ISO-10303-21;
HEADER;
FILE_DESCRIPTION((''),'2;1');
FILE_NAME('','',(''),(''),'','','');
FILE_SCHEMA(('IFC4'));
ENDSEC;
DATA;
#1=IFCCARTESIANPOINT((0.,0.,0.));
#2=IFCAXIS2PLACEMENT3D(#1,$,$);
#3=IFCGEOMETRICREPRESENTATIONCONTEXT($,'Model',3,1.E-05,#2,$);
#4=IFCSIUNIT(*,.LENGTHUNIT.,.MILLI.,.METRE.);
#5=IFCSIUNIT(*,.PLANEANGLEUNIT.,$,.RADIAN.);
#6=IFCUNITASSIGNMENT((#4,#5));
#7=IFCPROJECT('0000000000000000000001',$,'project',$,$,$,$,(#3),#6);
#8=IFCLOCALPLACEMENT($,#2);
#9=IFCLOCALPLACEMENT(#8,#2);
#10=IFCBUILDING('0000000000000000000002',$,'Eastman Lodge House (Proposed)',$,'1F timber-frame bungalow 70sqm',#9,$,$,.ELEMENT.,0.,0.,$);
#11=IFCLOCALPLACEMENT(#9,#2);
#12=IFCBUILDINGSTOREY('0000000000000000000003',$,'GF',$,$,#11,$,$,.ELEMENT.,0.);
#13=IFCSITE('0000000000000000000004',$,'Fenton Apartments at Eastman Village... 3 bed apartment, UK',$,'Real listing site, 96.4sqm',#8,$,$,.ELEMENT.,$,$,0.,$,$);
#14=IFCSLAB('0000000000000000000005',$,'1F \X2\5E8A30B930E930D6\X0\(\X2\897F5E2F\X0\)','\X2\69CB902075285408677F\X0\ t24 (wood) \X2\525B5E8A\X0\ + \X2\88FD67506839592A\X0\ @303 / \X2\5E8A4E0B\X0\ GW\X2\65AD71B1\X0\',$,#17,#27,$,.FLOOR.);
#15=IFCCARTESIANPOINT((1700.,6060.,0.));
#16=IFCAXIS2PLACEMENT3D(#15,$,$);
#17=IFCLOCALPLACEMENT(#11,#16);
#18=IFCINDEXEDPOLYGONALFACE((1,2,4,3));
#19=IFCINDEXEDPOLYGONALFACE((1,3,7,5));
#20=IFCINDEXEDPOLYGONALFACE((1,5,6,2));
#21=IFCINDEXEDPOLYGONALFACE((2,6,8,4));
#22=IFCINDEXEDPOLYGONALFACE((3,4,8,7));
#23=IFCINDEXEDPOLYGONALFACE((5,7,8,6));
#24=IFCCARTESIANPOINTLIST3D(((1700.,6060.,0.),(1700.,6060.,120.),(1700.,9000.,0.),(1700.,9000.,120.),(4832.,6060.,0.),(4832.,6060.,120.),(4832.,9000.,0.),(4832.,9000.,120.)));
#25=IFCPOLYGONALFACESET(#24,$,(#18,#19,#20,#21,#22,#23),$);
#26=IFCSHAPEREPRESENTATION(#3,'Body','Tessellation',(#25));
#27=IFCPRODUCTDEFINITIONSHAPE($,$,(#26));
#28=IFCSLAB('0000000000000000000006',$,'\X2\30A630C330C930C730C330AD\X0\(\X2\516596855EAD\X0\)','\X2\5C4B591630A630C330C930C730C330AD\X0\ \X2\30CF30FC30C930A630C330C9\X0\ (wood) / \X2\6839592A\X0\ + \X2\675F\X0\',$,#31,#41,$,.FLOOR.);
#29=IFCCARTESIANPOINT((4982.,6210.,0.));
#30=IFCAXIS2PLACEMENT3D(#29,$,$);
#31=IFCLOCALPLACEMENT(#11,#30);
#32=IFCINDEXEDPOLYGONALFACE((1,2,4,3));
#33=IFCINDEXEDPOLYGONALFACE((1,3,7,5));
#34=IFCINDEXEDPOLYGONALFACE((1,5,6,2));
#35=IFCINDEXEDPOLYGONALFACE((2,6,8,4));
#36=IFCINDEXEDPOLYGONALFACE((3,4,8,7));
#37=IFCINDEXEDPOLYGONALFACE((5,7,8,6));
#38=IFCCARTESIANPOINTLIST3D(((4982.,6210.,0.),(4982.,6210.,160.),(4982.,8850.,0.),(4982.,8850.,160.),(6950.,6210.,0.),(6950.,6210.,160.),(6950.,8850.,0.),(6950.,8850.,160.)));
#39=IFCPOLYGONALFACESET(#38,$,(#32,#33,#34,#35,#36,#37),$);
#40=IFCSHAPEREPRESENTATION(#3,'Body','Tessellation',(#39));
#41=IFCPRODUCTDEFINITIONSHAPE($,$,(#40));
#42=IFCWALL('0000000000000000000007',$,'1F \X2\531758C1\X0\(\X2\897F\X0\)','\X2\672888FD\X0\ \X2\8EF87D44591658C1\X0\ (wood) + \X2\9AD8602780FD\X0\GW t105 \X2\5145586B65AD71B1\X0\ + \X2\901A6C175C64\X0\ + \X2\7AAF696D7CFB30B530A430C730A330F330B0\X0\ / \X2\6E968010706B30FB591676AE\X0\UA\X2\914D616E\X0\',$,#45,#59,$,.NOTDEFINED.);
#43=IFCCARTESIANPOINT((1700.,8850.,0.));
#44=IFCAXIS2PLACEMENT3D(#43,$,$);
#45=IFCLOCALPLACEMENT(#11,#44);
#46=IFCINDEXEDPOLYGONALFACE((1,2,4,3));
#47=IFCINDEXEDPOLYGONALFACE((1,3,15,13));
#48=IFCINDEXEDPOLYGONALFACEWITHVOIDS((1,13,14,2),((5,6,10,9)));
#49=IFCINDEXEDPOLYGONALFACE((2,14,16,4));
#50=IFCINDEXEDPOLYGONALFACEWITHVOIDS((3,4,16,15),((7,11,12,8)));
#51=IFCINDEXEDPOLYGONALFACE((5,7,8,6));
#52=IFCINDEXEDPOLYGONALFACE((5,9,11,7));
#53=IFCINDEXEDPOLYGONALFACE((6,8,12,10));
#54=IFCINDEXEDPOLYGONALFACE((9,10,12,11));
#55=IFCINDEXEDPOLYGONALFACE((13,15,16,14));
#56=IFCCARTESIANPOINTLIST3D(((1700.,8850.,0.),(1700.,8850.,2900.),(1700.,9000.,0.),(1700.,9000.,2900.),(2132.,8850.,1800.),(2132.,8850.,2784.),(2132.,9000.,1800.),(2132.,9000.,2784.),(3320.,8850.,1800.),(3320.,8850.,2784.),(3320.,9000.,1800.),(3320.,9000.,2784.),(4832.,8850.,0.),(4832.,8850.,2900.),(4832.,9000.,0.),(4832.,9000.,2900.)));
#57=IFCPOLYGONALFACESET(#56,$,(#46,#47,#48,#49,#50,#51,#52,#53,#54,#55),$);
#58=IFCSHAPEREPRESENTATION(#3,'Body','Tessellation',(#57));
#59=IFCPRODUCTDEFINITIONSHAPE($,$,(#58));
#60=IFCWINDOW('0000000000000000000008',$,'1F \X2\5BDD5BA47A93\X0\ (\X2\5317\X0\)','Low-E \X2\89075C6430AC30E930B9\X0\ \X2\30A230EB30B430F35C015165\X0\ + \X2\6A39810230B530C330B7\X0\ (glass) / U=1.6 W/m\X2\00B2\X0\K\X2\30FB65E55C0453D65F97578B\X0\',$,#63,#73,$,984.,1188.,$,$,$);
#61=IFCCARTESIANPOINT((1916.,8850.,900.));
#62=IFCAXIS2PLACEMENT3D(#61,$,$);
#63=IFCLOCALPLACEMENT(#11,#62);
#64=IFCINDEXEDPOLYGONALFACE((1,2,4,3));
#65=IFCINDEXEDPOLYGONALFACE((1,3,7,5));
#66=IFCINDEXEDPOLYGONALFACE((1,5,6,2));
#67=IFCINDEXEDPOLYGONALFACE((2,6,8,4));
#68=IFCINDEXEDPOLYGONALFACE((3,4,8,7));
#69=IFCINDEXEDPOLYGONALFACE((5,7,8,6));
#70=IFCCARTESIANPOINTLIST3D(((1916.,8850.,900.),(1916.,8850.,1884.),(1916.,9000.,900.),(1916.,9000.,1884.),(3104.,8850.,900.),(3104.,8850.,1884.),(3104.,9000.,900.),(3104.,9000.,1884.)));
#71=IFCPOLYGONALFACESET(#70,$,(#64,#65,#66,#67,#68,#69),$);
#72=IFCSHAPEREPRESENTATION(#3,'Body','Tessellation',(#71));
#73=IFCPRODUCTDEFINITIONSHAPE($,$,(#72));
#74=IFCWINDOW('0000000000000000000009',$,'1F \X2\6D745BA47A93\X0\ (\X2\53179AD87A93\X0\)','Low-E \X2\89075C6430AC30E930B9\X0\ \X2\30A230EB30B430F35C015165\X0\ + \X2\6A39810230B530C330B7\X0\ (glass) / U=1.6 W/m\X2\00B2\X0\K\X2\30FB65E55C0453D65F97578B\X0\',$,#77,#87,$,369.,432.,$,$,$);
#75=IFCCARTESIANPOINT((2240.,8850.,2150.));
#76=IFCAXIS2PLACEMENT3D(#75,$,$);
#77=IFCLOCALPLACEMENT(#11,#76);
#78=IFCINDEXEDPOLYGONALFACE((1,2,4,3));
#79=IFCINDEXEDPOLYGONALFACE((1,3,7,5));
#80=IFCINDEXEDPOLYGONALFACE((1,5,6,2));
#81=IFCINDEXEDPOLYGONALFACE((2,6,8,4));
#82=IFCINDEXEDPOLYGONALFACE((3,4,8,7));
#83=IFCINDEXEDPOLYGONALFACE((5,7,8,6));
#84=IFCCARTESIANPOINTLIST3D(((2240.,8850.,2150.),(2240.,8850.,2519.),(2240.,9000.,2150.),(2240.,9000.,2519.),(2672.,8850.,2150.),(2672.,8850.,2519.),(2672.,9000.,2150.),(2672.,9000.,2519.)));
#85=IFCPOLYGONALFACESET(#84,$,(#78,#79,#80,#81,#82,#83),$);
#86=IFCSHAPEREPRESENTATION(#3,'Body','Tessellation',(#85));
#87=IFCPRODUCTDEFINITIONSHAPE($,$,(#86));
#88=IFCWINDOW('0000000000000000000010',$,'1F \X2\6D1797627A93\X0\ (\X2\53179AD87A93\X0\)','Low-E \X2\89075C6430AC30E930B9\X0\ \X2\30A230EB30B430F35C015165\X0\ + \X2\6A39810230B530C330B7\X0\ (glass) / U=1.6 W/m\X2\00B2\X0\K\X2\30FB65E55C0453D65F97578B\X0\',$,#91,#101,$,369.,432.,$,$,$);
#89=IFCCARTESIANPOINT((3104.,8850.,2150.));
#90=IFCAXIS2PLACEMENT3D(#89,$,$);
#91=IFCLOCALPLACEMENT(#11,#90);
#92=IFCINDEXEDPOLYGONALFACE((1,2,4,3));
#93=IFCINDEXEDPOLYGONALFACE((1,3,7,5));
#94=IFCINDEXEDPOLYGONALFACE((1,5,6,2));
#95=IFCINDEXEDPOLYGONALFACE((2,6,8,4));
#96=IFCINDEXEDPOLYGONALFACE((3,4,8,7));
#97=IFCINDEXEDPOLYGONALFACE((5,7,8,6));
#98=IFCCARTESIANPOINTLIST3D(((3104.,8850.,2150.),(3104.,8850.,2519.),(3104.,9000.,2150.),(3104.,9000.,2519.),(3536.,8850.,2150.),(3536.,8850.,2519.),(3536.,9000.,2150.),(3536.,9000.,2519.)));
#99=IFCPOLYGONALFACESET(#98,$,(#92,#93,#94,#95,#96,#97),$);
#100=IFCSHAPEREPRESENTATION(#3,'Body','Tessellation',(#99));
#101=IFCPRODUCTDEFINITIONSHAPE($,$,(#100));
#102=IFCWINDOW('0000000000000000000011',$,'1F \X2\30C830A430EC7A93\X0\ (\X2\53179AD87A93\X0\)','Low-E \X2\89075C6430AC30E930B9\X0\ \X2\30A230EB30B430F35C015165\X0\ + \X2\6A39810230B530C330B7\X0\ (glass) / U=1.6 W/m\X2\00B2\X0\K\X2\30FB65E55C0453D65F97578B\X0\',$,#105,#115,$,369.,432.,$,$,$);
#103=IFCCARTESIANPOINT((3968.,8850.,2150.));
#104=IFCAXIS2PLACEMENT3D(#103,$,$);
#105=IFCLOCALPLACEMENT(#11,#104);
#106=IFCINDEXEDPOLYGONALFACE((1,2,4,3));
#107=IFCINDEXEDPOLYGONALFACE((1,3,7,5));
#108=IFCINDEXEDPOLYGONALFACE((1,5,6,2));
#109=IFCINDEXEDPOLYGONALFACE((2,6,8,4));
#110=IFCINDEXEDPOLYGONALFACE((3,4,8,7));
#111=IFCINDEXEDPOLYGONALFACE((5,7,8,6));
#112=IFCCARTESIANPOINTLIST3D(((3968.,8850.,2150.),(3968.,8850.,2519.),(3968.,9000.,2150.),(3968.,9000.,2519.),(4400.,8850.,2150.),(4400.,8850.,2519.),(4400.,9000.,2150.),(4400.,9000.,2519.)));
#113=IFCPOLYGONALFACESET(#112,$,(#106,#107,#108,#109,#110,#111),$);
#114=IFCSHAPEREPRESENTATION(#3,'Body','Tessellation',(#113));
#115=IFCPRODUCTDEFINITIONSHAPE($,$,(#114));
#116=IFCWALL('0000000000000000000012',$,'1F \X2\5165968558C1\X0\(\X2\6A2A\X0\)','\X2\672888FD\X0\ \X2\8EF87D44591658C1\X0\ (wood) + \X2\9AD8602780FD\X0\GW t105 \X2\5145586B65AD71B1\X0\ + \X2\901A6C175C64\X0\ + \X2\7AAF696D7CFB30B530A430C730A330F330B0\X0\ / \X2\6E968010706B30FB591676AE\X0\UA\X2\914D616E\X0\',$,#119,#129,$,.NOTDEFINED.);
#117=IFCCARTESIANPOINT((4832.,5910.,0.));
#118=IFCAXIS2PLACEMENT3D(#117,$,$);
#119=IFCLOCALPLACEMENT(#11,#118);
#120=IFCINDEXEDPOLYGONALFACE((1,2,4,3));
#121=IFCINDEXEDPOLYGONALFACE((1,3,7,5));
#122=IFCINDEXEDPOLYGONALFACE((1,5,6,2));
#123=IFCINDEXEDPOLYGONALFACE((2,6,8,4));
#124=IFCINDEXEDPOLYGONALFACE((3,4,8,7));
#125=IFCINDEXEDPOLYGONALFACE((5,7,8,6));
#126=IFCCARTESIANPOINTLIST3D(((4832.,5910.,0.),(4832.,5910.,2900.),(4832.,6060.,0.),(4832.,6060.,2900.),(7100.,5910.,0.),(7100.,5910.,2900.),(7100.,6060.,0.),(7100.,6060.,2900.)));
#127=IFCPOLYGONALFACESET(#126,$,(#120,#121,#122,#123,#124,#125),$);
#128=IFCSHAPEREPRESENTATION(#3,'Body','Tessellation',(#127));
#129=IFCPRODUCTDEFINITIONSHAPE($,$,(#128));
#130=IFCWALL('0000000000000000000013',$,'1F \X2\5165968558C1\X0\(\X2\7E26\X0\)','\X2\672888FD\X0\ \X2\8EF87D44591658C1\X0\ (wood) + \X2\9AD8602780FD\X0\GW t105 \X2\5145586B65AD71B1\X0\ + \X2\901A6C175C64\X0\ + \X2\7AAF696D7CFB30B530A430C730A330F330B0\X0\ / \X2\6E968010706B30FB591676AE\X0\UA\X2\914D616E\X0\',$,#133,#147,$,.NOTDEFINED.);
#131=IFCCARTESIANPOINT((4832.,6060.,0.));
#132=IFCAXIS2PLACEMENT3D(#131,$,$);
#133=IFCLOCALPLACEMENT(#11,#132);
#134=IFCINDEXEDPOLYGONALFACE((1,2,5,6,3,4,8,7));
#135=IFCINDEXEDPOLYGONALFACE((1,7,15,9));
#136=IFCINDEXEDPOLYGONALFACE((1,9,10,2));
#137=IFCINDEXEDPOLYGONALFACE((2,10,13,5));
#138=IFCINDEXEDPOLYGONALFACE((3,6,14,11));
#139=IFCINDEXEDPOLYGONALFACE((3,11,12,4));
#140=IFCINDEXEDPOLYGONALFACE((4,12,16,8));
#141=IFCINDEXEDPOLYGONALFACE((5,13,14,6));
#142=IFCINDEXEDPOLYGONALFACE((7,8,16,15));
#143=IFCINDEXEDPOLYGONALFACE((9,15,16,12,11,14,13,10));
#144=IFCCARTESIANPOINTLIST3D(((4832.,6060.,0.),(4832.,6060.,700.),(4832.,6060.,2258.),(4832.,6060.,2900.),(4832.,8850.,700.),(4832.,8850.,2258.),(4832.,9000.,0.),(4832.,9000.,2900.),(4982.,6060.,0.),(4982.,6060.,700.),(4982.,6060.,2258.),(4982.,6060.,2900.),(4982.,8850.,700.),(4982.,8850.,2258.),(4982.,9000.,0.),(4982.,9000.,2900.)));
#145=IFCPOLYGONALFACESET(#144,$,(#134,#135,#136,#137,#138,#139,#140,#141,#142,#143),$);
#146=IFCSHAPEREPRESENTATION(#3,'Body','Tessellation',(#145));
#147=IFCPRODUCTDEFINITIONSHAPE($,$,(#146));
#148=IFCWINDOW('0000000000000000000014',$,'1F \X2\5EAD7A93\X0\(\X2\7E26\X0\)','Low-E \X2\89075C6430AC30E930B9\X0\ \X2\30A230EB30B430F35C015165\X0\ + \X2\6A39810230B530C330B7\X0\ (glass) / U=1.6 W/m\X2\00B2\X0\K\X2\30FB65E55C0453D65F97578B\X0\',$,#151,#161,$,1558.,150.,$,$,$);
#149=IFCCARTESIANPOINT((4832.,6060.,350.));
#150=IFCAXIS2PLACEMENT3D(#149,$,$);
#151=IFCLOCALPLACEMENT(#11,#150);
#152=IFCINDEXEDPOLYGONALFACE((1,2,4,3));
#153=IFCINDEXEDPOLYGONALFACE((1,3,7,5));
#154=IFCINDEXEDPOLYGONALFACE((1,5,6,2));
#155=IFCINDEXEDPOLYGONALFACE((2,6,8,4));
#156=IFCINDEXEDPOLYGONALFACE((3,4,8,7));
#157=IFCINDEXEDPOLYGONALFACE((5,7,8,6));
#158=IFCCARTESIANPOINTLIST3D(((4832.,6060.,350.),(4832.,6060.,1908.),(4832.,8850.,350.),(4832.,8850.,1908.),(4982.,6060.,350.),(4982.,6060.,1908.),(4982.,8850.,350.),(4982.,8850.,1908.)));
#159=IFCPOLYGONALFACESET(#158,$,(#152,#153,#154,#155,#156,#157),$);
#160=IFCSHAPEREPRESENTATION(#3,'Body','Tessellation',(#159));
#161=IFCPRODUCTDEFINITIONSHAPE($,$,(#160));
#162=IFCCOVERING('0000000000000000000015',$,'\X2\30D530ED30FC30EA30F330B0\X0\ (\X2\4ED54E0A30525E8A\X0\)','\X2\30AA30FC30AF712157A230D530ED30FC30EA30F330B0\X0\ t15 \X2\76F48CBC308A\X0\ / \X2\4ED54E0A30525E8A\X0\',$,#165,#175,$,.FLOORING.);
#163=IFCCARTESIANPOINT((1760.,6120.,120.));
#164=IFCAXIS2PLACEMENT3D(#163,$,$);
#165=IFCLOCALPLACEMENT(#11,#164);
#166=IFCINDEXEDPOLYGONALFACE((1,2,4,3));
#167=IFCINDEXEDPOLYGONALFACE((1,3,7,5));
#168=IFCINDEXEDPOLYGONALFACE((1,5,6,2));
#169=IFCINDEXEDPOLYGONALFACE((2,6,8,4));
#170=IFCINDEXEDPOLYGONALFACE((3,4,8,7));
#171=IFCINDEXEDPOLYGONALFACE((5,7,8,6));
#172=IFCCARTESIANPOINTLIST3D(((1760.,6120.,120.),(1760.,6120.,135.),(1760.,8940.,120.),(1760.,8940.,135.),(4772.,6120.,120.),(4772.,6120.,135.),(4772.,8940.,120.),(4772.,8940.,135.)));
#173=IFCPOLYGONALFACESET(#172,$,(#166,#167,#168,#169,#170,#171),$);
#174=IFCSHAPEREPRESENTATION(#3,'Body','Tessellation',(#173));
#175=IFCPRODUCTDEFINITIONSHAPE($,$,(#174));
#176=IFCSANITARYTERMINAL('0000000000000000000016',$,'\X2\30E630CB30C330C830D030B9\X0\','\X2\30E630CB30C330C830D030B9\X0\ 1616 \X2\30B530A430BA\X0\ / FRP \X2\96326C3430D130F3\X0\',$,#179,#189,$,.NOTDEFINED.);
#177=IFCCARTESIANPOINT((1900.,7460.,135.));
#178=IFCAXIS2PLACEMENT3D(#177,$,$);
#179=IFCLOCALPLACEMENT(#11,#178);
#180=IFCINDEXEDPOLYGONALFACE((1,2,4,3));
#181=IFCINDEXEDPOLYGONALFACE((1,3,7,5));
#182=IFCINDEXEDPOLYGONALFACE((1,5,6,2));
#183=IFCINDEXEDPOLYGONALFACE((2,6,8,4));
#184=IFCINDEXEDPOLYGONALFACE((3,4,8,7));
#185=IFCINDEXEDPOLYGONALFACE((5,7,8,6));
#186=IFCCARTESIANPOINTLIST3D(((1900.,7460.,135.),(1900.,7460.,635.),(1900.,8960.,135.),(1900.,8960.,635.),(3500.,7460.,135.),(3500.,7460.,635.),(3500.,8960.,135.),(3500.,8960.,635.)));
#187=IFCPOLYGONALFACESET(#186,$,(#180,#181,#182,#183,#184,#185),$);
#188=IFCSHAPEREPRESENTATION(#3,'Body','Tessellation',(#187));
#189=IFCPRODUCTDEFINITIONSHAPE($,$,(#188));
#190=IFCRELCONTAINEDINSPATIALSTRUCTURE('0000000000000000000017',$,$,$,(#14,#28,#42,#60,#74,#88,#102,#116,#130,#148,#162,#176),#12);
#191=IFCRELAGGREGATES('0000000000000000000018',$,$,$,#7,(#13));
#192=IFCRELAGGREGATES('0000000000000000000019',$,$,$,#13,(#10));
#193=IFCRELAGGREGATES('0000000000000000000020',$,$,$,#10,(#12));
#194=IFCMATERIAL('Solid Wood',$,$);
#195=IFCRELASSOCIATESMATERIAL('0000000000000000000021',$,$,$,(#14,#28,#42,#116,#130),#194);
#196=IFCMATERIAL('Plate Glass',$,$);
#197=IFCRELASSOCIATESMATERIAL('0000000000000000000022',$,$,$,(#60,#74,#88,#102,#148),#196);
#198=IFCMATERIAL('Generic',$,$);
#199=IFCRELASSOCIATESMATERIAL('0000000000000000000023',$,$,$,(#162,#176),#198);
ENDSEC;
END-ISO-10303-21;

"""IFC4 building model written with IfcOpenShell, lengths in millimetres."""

from ifc_helpers import new_model, si_unit, frame, frame_2d, origin, place, context, project, spatial, rectangle, extrude, material, element, fill, save


model = new_model("IFC4")

# Units and contexts
model_context = context("Model", 3, precision=1e-05, world=origin())
ifc_project = project(units=[si_unit("LENGTHUNIT", "METRE", prefix="MILLI"), si_unit("PLANEANGLEUNIT", "RADIAN")], contexts=[model_context])

# Site, building, storey
site_placement = place(None, origin())
site = spatial("IfcSite", under=ifc_project, at=site_placement, Name="Fenton Apartments at Eastman Village... 3 bed apartment, UK", ObjectType="Real listing site, 96.4sqm", CompositionType="ELEMENT", RefElevation=0.0)
building_placement = place(site_placement, origin())
building = spatial("IfcBuilding", under=site, at=building_placement, Name="Eastman Lodge House (Proposed)", ObjectType="1F timber-frame bungalow 70sqm", CompositionType="ELEMENT", ElevationOfRefHeight=0.0, ElevationOfTerrain=0.0)
storey_placement = place(building_placement, origin())
storey = spatial("IfcBuildingStorey", under=building, at=storey_placement, Name="GF", CompositionType="ELEMENT", Elevation=0.0)

# Slabs
ifc_material_1 = material(Name="Solid Wood")
slab_1_placement = place(storey_placement, frame((1700.0, 6060.0, 0.0)))
element("IfcSlab", 1, at=slab_1_placement, inside=storey, material=ifc_material_1, Name="1F 床スラブ(西帯)", Description="構造用合板 t24 (wood) 剛床 + 製材根太 @303 / 床下 GW断熱", PredefinedType="FLOOR", context=model_context, shape_type="SweptSolid", body=[
    extrude(rectangle(XDim=3132.0, YDim=2940.0, at=frame_2d((1566.0, 1470.0))), frame((1700.0, 6060.0, 0.0)), (0.0, 0.0, 1.0), 120.0),
])
slab_2_placement = place(storey_placement, frame((4982.0, 6210.0, 0.0)))
element("IfcSlab", 2, at=slab_2_placement, inside=storey, material=ifc_material_1, Name="ウッドデッキ(入隅庭)", Description="屋外ウッドデッキ ハードウッド (wood) / 根太 + 束", PredefinedType="FLOOR", context=model_context, shape_type="SweptSolid", body=[
    extrude(rectangle(XDim=1968.0, YDim=2640.0, at=frame_2d((984.0, 1320.0))), frame((4982.0, 6210.0, 0.0)), (0.0, 0.0, 1.0), 160.0),
])

# Wall, openings, windows
wall_1_placement = place(storey_placement, frame((1700.0, 8850.0, 0.0)))
wall_1 = element("IfcWall", 3, at=wall_1_placement, inside=storey, material=ifc_material_1, Name="1F 北壁(西)", Description="木製 軸組外壁 (wood) + 高性能GW t105 充填断熱 + 通気層 + 窯業系サイディング / 準耐火・外皮UA配慮", PredefinedType="NOTDEFINED", context=model_context, shape_type="SweptSolid", body=[
    extrude(rectangle(XDim=3132.0, YDim=150.0, at=frame_2d((1566.0, 75.0))), frame((1700.0, 8850.0, 0.0)), (0.0, 0.0, 1.0), 2900.0),
])
opening_1_placement = place(storey_placement, frame((1916.0, 8850.0, 900.0)))
opening_1 = element("IfcOpeningElement", 4, at=opening_1_placement, cuts=wall_1, PredefinedType="NOTDEFINED", context=model_context, shape_type="SweptSolid", body=[
    extrude(rectangle(XDim=1188.0, YDim=150.0, at=frame_2d((594.0, 75.0))), frame((1916.0, 8850.0, 900.0)), (0.0, 0.0, 1.0), 984.0),
])
opening_2_placement = place(storey_placement, frame((2240.0, 8850.0, 2150.0)))
opening_2 = element("IfcOpeningElement", 5, at=opening_2_placement, cuts=wall_1, PredefinedType="NOTDEFINED", context=model_context, shape_type="SweptSolid", body=[
    extrude(rectangle(XDim=432.0, YDim=150.0, at=frame_2d((216.0, 75.0))), frame((2240.0, 8850.0, 2150.0)), (0.0, 0.0, 1.0), 369.0),
])
opening_3_placement = place(storey_placement, frame((3104.0, 8850.0, 2150.0)))
opening_3 = element("IfcOpeningElement", 6, at=opening_3_placement, cuts=wall_1, PredefinedType="NOTDEFINED", context=model_context, shape_type="SweptSolid", body=[
    extrude(rectangle(XDim=432.0, YDim=150.0, at=frame_2d((216.0, 75.0))), frame((3104.0, 8850.0, 2150.0)), (0.0, 0.0, 1.0), 369.0),
])
opening_4_placement = place(storey_placement, frame((3968.0, 8850.0, 2150.0)))
opening_4 = element("IfcOpeningElement", 7, at=opening_4_placement, cuts=wall_1, PredefinedType="NOTDEFINED", context=model_context, shape_type="SweptSolid", body=[
    extrude(rectangle(XDim=432.0, YDim=150.0, at=frame_2d((216.0, 75.0))), frame((3968.0, 8850.0, 2150.0)), (0.0, 0.0, 1.0), 369.0),
])
ifc_material_2 = material(Name="Plate Glass")
window_1_placement = place(storey_placement, frame((1916.0, 8850.0, 900.0)))
window_1 = element("IfcWindow", 8, at=window_1_placement, inside=storey, material=ifc_material_2, Name="1F 寝室窓 (北)", Description="Low-E 複層ガラス アルゴン封入 + 樹脂サッシ (glass) / U=1.6 W/m²K・日射取得型", OverallHeight=984.0, OverallWidth=1188.0, context=model_context, shape_type="SweptSolid", body=[
    extrude(rectangle(XDim=1188.0, YDim=150.0, at=frame_2d((594.0, 75.0))), frame((1916.0, 8850.0, 900.0)), (0.0, 0.0, 1.0), 984.0),
])
fill(opening_1, window_1)
window_2_placement = place(storey_placement, frame((2240.0, 8850.0, 2150.0)))
window_2 = element("IfcWindow", 9, at=window_2_placement, inside=storey, material=ifc_material_2, Name="1F 浴室窓 (北高窓)", Description="Low-E 複層ガラス アルゴン封入 + 樹脂サッシ (glass) / U=1.6 W/m²K・日射取得型", OverallHeight=369.0, OverallWidth=432.0, context=model_context, shape_type="SweptSolid", body=[
    extrude(rectangle(XDim=432.0, YDim=150.0, at=frame_2d((216.0, 75.0))), frame((2240.0, 8850.0, 2150.0)), (0.0, 0.0, 1.0), 369.0),
])
fill(opening_2, window_2)
window_3_placement = place(storey_placement, frame((3104.0, 8850.0, 2150.0)))
window_3 = element("IfcWindow", 10, at=window_3_placement, inside=storey, material=ifc_material_2, Name="1F 洗面窓 (北高窓)", Description="Low-E 複層ガラス アルゴン封入 + 樹脂サッシ (glass) / U=1.6 W/m²K・日射取得型", OverallHeight=369.0, OverallWidth=432.0, context=model_context, shape_type="SweptSolid", body=[
    extrude(rectangle(XDim=432.0, YDim=150.0, at=frame_2d((216.0, 75.0))), frame((3104.0, 8850.0, 2150.0)), (0.0, 0.0, 1.0), 369.0),
])
fill(opening_3, window_3)
window_4_placement = place(storey_placement, frame((3968.0, 8850.0, 2150.0)))
window_4 = element("IfcWindow", 11, at=window_4_placement, inside=storey, material=ifc_material_2, Name="1F トイレ窓 (北高窓)", Description="Low-E 複層ガラス アルゴン封入 + 樹脂サッシ (glass) / U=1.6 W/m²K・日射取得型", OverallHeight=369.0, OverallWidth=432.0, context=model_context, shape_type="SweptSolid", body=[
    extrude(rectangle(XDim=432.0, YDim=150.0, at=frame_2d((216.0, 75.0))), frame((3968.0, 8850.0, 2150.0)), (0.0, 0.0, 1.0), 369.0),
])
fill(opening_4, window_4)

# Wall
wall_2_placement = place(storey_placement, frame((4832.0, 5910.0, 0.0)))
element("IfcWall", 12, at=wall_2_placement, inside=storey, material=ifc_material_1, Name="1F 入隅壁(横)", Description="木製 軸組外壁 (wood) + 高性能GW t105 充填断熱 + 通気層 + 窯業系サイディング / 準耐火・外皮UA配慮", PredefinedType="NOTDEFINED", context=model_context, shape_type="SweptSolid", body=[
    extrude(rectangle(XDim=2268.0, YDim=150.0, at=frame_2d((1134.0, 75.0))), frame((4832.0, 5910.0, 0.0)), (0.0, 0.0, 1.0), 2900.0),
])

# Wall, opening, window
wall_3_placement = place(storey_placement, frame((4832.0, 6060.0, 0.0)))
wall_3 = element("IfcWall", 13, at=wall_3_placement, inside=storey, material=ifc_material_1, Name="1F 入隅壁(縦)", Description="木製 軸組外壁 (wood) + 高性能GW t105 充填断熱 + 通気層 + 窯業系サイディング / 準耐火・外皮UA配慮", PredefinedType="NOTDEFINED", context=model_context, shape_type="SweptSolid", body=[
    extrude(rectangle(XDim=150.0, YDim=2940.0, at=frame_2d((75.0, 1470.0))), frame((4832.0, 6060.0, 0.0)), (0.0, 0.0, 1.0), 2900.0),
])
opening_5_placement = place(storey_placement, frame((4832.0, 6060.0, 350.0)))
opening_5 = element("IfcOpeningElement", 14, at=opening_5_placement, cuts=wall_3, PredefinedType="NOTDEFINED", context=model_context, shape_type="SweptSolid", body=[
    extrude(rectangle(XDim=150.0, YDim=2790.0, at=frame_2d((75.0, 1395.0))), frame((4832.0, 6060.0, 350.0)), (0.0, 0.0, 1.0), 1558.0),
])
window_5_placement = place(storey_placement, frame((4832.0, 6060.0, 350.0)))
window_5 = element("IfcWindow", 15, at=window_5_placement, inside=storey, material=ifc_material_2, Name="1F 庭窓(縦)", Description="Low-E 複層ガラス アルゴン封入 + 樹脂サッシ (glass) / U=1.6 W/m²K・日射取得型", OverallHeight=1558.0, OverallWidth=150.0, context=model_context, shape_type="SweptSolid", body=[
    extrude(rectangle(XDim=150.0, YDim=2790.0, at=frame_2d((75.0, 1395.0))), frame((4832.0, 6060.0, 350.0)), (0.0, 0.0, 1.0), 1558.0),
])
fill(opening_5, window_5)

# Covering
ifc_material_3 = material(Name="Generic")
covering_placement = place(storey_placement, frame((1760.0, 6120.0, 120.0)))
element("IfcCovering", 16, at=covering_placement, inside=storey, material=ifc_material_3, Name="フローリング (仕上げ床)", Description="オーク無垢フローリング t15 直貼り / 仕上げ床", PredefinedType="FLOORING", context=model_context, shape_type="SweptSolid", body=[
    extrude(rectangle(XDim=3012.0, YDim=2820.0, at=frame_2d((1506.0, 1410.0))), frame((1760.0, 6120.0, 120.0)), (0.0, 0.0, 1.0), 15.0),
])

# Sanitary terminal
sanitary_terminal_1_placement = place(storey_placement, frame((1900.0, 7460.0, 135.0)))
element("IfcSanitaryTerminal", 17, at=sanitary_terminal_1_placement, inside=storey, material=ifc_material_3, Name="ユニットバス", Description="ユニットバス 1616 サイズ / FRP 防水パン", PredefinedType="NOTDEFINED", context=model_context, shape_type="SweptSolid", body=[
    extrude(rectangle(XDim=1600.0, YDim=1500.0, at=frame_2d((800.0, 750.0))), frame((1900.0, 7460.0, 135.0)), (0.0, 0.0, 1.0), 500.0),
])

save(model, "model.ifc")
